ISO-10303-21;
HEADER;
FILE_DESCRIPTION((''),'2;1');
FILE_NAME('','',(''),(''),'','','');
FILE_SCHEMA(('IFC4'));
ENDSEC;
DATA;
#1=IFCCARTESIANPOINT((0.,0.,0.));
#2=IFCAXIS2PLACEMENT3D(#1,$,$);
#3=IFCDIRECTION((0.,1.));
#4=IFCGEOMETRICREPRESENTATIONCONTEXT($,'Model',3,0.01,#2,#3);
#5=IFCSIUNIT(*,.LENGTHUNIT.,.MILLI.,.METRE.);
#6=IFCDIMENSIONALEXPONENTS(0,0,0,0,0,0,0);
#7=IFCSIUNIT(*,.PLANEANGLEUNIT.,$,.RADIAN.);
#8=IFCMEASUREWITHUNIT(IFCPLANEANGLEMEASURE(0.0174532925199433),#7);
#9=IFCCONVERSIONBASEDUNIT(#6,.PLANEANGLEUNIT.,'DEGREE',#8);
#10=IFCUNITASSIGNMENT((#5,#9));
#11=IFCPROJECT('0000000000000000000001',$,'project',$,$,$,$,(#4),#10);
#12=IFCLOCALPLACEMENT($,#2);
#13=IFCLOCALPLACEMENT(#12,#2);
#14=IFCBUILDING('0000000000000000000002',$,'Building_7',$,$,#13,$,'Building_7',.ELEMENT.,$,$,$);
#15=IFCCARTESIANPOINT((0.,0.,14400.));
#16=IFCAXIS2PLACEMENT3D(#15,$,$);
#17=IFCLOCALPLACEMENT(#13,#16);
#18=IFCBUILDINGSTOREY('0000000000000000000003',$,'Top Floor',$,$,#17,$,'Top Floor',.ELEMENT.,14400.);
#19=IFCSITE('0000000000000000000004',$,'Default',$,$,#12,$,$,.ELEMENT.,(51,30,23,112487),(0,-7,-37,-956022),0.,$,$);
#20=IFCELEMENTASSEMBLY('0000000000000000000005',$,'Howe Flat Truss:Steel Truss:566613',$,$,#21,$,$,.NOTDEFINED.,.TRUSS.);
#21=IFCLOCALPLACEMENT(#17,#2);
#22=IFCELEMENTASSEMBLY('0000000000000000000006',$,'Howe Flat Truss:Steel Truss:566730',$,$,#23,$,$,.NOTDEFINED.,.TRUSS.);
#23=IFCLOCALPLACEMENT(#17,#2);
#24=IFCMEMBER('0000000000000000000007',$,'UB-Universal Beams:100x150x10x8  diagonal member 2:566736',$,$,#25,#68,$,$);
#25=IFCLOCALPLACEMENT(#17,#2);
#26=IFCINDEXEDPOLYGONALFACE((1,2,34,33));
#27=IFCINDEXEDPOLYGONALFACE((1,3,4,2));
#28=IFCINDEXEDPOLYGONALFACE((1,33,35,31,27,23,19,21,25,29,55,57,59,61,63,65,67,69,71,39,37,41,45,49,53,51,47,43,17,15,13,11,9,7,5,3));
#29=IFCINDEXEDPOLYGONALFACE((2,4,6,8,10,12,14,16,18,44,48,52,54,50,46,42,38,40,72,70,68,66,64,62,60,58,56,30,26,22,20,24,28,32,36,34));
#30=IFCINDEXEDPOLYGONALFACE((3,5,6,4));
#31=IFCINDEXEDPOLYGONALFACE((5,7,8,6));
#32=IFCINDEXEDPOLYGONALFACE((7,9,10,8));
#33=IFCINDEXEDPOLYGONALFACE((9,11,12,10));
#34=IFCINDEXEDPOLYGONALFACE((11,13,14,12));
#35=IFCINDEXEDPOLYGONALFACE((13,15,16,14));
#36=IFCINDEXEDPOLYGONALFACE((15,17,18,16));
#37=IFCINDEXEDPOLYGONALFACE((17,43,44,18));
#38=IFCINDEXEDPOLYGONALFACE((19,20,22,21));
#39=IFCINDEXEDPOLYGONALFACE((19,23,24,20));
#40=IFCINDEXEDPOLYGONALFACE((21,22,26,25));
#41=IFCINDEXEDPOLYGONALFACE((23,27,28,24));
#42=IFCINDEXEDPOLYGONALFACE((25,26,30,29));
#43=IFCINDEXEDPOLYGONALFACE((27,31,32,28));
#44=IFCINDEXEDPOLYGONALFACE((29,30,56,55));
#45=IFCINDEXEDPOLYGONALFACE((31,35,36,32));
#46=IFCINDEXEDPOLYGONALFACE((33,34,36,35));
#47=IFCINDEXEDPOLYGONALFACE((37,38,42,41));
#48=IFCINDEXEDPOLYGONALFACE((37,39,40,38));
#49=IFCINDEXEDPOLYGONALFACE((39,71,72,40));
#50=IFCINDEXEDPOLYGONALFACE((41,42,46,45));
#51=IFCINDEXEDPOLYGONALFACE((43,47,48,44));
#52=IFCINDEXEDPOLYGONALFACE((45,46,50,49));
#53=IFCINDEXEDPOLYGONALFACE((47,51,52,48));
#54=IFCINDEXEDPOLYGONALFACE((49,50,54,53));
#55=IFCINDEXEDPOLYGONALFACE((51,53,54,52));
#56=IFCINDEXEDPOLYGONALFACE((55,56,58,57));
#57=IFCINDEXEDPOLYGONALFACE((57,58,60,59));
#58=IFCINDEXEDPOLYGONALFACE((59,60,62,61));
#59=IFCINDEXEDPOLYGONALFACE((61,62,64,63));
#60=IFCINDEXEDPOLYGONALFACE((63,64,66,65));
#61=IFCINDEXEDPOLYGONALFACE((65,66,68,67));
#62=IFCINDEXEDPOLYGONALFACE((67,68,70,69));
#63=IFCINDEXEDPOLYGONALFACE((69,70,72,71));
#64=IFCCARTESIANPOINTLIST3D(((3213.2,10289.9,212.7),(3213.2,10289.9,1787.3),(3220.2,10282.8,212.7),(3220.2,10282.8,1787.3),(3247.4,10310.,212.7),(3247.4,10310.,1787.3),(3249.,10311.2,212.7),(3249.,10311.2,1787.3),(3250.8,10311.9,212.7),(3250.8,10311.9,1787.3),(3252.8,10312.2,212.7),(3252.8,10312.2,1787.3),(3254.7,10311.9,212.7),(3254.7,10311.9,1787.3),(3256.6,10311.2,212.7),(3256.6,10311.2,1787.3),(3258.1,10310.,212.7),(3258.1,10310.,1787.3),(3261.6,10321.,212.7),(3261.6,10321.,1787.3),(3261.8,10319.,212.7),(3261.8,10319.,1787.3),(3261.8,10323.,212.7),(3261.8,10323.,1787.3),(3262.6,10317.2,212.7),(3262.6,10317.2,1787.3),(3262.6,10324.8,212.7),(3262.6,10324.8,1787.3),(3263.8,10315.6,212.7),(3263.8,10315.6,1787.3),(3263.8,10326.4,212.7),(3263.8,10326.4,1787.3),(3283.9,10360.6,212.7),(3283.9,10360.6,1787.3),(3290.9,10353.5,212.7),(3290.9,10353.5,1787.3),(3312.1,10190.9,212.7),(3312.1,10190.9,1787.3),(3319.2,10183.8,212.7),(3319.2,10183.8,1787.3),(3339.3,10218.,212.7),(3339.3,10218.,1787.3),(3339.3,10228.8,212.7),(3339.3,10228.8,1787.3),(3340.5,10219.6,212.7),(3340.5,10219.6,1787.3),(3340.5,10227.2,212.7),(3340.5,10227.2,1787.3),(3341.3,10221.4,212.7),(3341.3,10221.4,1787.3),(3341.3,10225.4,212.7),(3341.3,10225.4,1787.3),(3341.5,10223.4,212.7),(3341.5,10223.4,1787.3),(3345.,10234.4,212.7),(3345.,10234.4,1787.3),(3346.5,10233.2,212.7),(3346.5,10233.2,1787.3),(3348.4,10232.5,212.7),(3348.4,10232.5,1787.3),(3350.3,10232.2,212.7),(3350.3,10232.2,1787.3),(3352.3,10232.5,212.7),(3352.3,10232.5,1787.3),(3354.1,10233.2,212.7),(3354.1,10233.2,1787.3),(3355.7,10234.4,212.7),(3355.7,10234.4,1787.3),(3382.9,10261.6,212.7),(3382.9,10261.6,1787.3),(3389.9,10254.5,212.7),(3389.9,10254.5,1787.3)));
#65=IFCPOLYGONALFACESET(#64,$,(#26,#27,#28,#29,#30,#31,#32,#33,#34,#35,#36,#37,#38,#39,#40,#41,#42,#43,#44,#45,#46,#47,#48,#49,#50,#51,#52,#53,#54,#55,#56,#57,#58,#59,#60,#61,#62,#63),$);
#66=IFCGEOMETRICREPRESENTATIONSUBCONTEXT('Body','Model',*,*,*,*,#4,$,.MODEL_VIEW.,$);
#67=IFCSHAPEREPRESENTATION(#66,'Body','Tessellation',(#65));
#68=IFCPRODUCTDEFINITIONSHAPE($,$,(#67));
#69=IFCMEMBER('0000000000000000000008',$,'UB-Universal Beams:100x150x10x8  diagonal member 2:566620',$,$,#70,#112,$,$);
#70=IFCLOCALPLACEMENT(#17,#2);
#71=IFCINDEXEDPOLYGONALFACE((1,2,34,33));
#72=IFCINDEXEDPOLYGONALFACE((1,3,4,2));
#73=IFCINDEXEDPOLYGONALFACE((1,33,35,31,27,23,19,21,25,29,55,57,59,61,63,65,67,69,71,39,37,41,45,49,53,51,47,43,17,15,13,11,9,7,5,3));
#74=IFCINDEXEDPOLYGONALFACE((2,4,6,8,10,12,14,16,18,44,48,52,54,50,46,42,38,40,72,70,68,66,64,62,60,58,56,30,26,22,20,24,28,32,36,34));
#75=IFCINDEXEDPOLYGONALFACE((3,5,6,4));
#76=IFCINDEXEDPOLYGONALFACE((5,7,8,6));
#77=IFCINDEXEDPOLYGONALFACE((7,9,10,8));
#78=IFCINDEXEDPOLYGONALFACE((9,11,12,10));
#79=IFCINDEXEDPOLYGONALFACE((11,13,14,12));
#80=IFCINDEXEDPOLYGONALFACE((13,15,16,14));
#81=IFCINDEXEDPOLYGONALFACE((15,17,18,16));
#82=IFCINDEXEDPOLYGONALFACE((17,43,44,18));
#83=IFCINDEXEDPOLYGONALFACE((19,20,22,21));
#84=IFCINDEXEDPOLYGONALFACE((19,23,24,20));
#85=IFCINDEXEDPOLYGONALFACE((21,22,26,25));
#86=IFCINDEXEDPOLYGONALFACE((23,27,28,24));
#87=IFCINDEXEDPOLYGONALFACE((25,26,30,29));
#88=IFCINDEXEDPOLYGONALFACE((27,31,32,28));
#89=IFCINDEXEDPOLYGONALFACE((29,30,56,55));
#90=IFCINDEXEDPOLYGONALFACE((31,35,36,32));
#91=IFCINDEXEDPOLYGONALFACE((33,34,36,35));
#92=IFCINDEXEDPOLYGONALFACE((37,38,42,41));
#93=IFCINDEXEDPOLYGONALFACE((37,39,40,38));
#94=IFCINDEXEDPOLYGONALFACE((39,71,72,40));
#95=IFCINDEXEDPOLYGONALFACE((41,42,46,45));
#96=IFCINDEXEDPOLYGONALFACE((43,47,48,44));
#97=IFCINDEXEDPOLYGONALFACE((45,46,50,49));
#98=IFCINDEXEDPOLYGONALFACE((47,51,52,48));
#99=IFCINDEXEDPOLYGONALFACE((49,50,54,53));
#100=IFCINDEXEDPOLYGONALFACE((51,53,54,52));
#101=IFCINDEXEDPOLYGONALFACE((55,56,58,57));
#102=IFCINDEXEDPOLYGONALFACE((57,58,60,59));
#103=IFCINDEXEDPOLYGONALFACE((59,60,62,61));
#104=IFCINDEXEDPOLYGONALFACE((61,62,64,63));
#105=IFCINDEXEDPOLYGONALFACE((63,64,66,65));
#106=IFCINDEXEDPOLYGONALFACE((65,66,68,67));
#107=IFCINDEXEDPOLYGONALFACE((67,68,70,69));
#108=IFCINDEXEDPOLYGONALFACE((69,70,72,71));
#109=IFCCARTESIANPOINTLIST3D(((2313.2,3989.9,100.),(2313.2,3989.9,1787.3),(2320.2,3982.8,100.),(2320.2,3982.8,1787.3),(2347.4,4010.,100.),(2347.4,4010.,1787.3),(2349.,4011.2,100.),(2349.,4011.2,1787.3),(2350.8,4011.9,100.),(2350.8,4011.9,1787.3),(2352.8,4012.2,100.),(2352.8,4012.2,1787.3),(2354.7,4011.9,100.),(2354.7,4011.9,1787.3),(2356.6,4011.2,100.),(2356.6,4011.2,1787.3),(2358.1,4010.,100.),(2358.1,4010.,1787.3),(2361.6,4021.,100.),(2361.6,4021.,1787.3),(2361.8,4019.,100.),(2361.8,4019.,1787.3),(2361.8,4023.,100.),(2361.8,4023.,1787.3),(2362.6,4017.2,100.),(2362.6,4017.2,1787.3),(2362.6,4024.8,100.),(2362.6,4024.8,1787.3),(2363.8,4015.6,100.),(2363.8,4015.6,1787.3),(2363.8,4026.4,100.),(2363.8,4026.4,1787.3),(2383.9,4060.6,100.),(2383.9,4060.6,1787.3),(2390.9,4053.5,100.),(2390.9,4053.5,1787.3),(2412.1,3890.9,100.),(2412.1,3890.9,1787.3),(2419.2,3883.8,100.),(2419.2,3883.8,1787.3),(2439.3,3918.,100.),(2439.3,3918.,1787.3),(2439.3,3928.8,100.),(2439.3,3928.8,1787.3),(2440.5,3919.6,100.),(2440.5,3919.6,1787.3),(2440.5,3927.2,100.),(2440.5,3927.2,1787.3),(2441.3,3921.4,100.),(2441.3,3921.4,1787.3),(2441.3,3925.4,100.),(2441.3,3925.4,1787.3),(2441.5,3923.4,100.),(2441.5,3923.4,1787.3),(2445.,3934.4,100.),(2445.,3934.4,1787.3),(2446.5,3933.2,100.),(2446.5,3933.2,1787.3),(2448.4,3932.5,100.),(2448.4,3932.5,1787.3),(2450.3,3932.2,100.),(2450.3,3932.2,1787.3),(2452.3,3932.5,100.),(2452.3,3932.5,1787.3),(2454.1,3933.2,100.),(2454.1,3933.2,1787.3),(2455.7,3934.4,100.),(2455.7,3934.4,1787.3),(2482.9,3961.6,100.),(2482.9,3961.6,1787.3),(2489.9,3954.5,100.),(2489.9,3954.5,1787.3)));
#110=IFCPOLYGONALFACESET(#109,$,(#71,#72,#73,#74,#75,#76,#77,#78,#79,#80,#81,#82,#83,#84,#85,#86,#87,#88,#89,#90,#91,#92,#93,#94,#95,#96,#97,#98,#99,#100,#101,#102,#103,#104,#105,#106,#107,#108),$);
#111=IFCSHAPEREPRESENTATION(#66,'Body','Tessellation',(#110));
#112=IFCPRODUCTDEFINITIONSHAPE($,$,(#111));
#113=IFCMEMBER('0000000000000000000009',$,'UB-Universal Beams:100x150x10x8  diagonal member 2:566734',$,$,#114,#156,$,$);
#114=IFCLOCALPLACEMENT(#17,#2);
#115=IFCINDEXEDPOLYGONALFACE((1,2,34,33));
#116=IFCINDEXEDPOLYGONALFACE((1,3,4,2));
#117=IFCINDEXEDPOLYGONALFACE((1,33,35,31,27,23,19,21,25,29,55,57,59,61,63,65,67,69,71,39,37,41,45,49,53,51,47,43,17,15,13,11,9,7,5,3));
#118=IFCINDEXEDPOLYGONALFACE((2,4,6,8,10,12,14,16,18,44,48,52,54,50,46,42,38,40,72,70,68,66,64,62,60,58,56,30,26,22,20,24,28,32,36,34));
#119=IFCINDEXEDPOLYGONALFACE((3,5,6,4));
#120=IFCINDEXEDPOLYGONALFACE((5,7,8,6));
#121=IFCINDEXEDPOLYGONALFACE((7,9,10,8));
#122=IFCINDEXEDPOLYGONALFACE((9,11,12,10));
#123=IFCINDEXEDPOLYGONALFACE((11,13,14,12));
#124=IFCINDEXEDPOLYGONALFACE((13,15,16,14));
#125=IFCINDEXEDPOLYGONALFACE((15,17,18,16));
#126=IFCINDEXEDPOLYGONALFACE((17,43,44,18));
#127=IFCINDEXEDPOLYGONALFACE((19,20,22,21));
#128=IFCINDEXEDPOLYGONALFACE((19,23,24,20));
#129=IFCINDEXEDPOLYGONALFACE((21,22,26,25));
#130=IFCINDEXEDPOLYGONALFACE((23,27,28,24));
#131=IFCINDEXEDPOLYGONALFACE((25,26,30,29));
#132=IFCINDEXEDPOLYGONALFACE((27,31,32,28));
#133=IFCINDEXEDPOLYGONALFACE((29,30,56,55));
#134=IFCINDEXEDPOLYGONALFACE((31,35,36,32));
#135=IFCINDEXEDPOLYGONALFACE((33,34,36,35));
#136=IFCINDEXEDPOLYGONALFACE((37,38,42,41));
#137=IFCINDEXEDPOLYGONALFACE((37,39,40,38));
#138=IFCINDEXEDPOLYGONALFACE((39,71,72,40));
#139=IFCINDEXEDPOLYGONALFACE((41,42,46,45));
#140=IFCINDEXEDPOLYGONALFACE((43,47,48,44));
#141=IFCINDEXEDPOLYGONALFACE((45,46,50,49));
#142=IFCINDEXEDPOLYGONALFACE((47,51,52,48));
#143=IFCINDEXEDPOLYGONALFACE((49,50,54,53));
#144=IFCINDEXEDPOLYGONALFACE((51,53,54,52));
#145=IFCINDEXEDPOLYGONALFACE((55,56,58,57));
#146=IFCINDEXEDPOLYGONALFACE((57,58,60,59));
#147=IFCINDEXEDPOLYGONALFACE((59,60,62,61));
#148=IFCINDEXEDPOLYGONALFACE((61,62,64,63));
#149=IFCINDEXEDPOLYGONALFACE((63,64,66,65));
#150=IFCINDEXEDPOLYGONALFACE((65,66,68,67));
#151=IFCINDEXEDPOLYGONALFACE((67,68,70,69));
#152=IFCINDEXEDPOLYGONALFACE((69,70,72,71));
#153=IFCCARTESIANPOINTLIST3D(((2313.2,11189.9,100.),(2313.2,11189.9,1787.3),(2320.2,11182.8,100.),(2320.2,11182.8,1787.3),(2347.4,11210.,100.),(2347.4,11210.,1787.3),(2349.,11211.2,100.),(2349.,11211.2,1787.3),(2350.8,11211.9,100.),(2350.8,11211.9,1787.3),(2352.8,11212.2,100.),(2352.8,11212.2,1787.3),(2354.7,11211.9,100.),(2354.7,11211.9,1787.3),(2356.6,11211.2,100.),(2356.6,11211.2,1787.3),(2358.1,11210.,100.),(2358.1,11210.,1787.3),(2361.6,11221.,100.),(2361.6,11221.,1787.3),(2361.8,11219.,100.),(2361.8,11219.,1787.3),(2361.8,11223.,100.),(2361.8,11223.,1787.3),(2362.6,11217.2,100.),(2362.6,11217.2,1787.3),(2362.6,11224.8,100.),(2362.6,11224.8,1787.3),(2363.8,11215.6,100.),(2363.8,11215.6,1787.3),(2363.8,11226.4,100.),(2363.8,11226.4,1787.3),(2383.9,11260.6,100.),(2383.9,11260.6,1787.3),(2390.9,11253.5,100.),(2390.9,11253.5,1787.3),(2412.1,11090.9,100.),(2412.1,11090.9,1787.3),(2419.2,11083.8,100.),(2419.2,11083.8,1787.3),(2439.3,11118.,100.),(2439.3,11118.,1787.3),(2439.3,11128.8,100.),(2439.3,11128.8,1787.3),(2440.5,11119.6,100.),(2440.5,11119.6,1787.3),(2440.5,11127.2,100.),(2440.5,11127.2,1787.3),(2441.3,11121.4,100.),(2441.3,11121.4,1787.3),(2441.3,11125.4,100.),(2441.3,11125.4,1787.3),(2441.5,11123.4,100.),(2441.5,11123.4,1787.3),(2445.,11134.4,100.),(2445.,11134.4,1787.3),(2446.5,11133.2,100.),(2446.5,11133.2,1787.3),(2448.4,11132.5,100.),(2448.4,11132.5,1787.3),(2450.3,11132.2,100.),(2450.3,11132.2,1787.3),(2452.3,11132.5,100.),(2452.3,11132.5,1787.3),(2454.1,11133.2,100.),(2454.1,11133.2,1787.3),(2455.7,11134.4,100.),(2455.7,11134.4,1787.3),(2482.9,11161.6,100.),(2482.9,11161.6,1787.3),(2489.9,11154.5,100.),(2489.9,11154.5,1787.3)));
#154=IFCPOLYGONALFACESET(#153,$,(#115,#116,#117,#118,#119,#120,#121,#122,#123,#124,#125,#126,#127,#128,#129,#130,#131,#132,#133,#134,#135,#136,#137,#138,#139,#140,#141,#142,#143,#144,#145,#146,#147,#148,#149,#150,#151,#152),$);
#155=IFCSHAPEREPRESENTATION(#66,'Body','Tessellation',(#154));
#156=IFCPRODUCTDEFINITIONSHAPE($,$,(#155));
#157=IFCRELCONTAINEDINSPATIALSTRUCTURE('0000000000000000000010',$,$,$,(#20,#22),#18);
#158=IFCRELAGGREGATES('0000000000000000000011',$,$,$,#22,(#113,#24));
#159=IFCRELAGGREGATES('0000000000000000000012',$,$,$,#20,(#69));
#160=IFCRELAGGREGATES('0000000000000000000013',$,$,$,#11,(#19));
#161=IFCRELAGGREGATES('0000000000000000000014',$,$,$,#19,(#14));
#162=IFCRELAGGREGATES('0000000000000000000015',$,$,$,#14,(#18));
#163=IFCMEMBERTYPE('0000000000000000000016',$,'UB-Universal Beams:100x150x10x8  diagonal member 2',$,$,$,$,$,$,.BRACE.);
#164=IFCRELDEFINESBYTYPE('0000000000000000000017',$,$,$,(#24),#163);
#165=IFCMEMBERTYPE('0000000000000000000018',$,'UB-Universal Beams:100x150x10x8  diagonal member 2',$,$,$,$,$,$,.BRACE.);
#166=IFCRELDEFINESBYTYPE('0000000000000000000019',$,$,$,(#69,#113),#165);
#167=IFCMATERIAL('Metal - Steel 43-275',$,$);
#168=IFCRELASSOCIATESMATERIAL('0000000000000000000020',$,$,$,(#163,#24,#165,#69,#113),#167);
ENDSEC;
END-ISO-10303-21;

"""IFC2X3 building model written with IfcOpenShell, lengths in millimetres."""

from ifc_helpers import new_model, entity, si_unit, converted_unit, direction, frame, frame_2d, origin, place, context, subcontext, project, spatial, polyline, circle_curve, parameter, trimmed, segment, composite_curve, outline, extrude, source, transform, mapped, material, type_object, type_shapes, element, aggregate, save


model = new_model("IFC2X3")

# Units and contexts
model_context = context("Model", 3, precision=0.01, world=origin(), true_north=direction((0.0, 1.0)))
body_context = subcontext(model_context, "Body", "Model", "MODEL_VIEW")
ifc_project = project(units=[si_unit("LENGTHUNIT", "METRE", prefix="MILLI"), converted_unit("PLANEANGLEUNIT", "DEGREE", entity("IfcPlaneAngleMeasure", 0.0174532925199433), si_unit("PLANEANGLEUNIT", "RADIAN"), dimensions=[0, 0, 0, 0, 0, 0, 0])], contexts=[model_context])

# Site, building, storey
site_placement = place(None, origin())
site = spatial("IfcSite", under=ifc_project, at=site_placement, Name="Default", CompositionType="ELEMENT", RefLatitude=(51, 30, 23, 112487), RefLongitude=(0, -7, -37, -956022), RefElevation=0.0)
building_placement = place(site_placement, origin())
building = spatial("IfcBuilding", under=site, at=building_placement, Name="Building_7", LongName="Building_7", CompositionType="ELEMENT")
storey_placement = place(building_placement, frame((0.0, 0.0, 14400.0)))
storey = spatial("IfcBuildingStorey", under=building, at=storey_placement, Name="Top Floor", LongName="Top Floor", CompositionType="ELEMENT", Elevation=14400.0)

# Shared definitions
ifc_material = material(Name="Metal - Steel 43-275")

# Element assemblies, member
assembly_1_placement = place(storey_placement, origin())
assembly_1 = element("IfcElementAssembly", 1, at=assembly_1_placement, inside=storey, Name="Howe Flat Truss:Steel Truss:566613", AssemblyPlace="NOTDEFINED", PredefinedType="TRUSS")
member_type_1 = type_object("IfcMemberType", Name="UB-Universal Beams:100x150x10x8  diagonal member 2", PredefinedType="BRACE", material=ifc_material)
shared_shape_1 = source(origin(), body_context, "Body", "SweptSolid", [
    extrude(outline(composite_curve([segment(polyline([(-50.0, -65.0), (-50.0, -75.0)]), True, "CONTINUOUS"), segment(polyline([(-50.0, -75.0), (50.0, -75.0)]), True, "CONTINUOUS"), segment(polyline([(50.0, -75.0), (50.0, -65.0)]), True, "CONTINUOUS"), segment(polyline([(50.0, -65.0), (11.6, -65.0)]), True, "CONTINUOUS"), segment(trimmed(circle_curve(frame_2d((11.6, -57.4), x_axis=(1.0, 0.0)), 7.6), [parameter(180.0)], [parameter(270.0)], True, "PARAMETER"), False, "CONTINUOUS"), segment(polyline([(4.0, -57.4), (4.0, 57.4)]), True, "CONTINUOUS"), segment(trimmed(circle_curve(frame_2d((11.6, 57.4), x_axis=(1.0, 0.0)), 7.6), [parameter(90.0)], [parameter(180.0)], True, "PARAMETER"), False, "CONTINUOUS"), segment(polyline([(11.6, 65.0), (50.0, 65.0)]), True, "CONTINUOUS"), segment(polyline([(50.0, 65.0), (50.0, 75.0)]), True, "CONTINUOUS"), segment(polyline([(50.0, 75.0), (-50.0, 75.0)]), True, "CONTINUOUS"), segment(polyline([(-50.0, 75.0), (-50.0, 65.0)]), True, "CONTINUOUS"), segment(polyline([(-50.0, 65.0), (-11.6, 65.0)]), True, "CONTINUOUS"), segment(trimmed(circle_curve(frame_2d((-11.6, 57.4), x_axis=(1.0, 0.0)), 7.6), [parameter(360.0)], [parameter(90.0)], True, "PARAMETER"), False, "CONTINUOUS"), segment(polyline([(-4.0, 57.4), (-4.0, -57.4)]), True, "CONTINUOUS"), segment(trimmed(circle_curve(frame_2d((-11.6, -57.4), x_axis=(1.0, 0.0)), 7.6), [parameter(270.0)], [parameter(360.0)], True, "PARAMETER"), False, "CONTINUOUS"), segment(polyline([(-11.6, -65.0), (-50.0, -65.0)]), True, "CONTINUOUS")], self_intersect=False)), frame((-787.3, 0.0, 0.0), z_axis=(-1.0, 0.0, 0.0), x_axis=(0.0, -1.0, 0.0)), (0.0, 0.0, -1.0), 1574.6),
])
type_shapes(member_type_1, [shared_shape_1])
assembly_2_placement = place(storey_placement, origin())
assembly_2 = element("IfcElementAssembly", 2, at=assembly_2_placement, inside=storey, Name="Howe Flat Truss:Steel Truss:566730", AssemblyPlace="NOTDEFINED", PredefinedType="TRUSS")
member_1_placement = place(assembly_2_placement, frame((3301.5, 10272.2, 1000.0), z_axis=(0.707107, -0.707107, 0.0), x_axis=(0.0, 0.0, 1.0)))
member_1 = element("IfcMember", 3, at=member_1_placement, type_object=member_type_1, material=ifc_material, Name="UB-Universal Beams:100x150x10x8  diagonal member 2:566736", context=body_context, shape_type="MappedRepresentation", body=[
    mapped(shared_shape_1, transform((0.0, 0.0, 0.0), scale=1.0)),
])

# Members
member_type_2 = type_object("IfcMemberType", Name="UB-Universal Beams:100x150x10x8  diagonal member 2", PredefinedType="BRACE", material=ifc_material)
shared_shape_2 = source(origin(), body_context, "Body", "SweptSolid", [
    extrude(outline(composite_curve([segment(polyline([(-50.0, -65.0), (-50.0, -75.0)]), True, "CONTINUOUS"), segment(polyline([(-50.0, -75.0), (50.0, -75.0)]), True, "CONTINUOUS"), segment(polyline([(50.0, -75.0), (50.0, -65.0)]), True, "CONTINUOUS"), segment(polyline([(50.0, -65.0), (11.6, -65.0)]), True, "CONTINUOUS"), segment(trimmed(circle_curve(frame_2d((11.6, -57.4), x_axis=(1.0, 0.0)), 7.6), [parameter(180.0)], [parameter(270.0)], True, "PARAMETER"), False, "CONTINUOUS"), segment(polyline([(4.0, -57.4), (4.0, 57.4)]), True, "CONTINUOUS"), segment(trimmed(circle_curve(frame_2d((11.6, 57.4), x_axis=(1.0, 0.0)), 7.6), [parameter(90.0)], [parameter(180.0)], True, "PARAMETER"), False, "CONTINUOUS"), segment(polyline([(11.6, 65.0), (50.0, 65.0)]), True, "CONTINUOUS"), segment(polyline([(50.0, 65.0), (50.0, 75.0)]), True, "CONTINUOUS"), segment(polyline([(50.0, 75.0), (-50.0, 75.0)]), True, "CONTINUOUS"), segment(polyline([(-50.0, 75.0), (-50.0, 65.0)]), True, "CONTINUOUS"), segment(polyline([(-50.0, 65.0), (-11.6, 65.0)]), True, "CONTINUOUS"), segment(trimmed(circle_curve(frame_2d((-11.6, 57.4), x_axis=(1.0, 0.0)), 7.6), [parameter(360.0)], [parameter(90.0)], True, "PARAMETER"), False, "CONTINUOUS"), segment(polyline([(-4.0, 57.4), (-4.0, -57.4)]), True, "CONTINUOUS"), segment(trimmed(circle_curve(frame_2d((-11.6, -57.4), x_axis=(1.0, 0.0)), 7.6), [parameter(270.0)], [parameter(360.0)], True, "PARAMETER"), False, "CONTINUOUS"), segment(polyline([(-11.6, -65.0), (-50.0, -65.0)]), True, "CONTINUOUS")], self_intersect=False)), frame((-900.0, 0.0, 0.0), z_axis=(-1.0, 0.0, 0.0), x_axis=(0.0, -1.0, 0.0)), (0.0, 0.0, -1.0), 1687.3),
])
type_shapes(member_type_2, [shared_shape_2])
member_2_placement = place(assembly_1_placement, frame((2401.5, 3972.2, 1000.0), z_axis=(0.707107, -0.707107, 0.0), x_axis=(0.0, 0.0, 1.0)))
member_2 = element("IfcMember", 4, at=member_2_placement, type_object=member_type_2, material=ifc_material, Name="UB-Universal Beams:100x150x10x8  diagonal member 2:566620", context=body_context, shape_type="MappedRepresentation", body=[
    mapped(shared_shape_2, transform((0.0, 0.0, 0.0), scale=1.0)),
])
member_3_placement = place(assembly_2_placement, frame((2401.5, 11172.2, 1000.0), z_axis=(0.707107, -0.707107, 0.0), x_axis=(0.0, 0.0, 1.0)))
member_3 = element("IfcMember", 5, at=member_3_placement, type_object=member_type_2, material=ifc_material, Name="UB-Universal Beams:100x150x10x8  diagonal member 2:566734", context=body_context, shape_type="MappedRepresentation", body=[
    mapped(shared_shape_2, transform((0.0, 0.0, 0.0), scale=1.0)),
])
aggregate(assembly_2, [member_3, member_1])
aggregate(assembly_1, [member_2])

save(model, "model.ifc")
